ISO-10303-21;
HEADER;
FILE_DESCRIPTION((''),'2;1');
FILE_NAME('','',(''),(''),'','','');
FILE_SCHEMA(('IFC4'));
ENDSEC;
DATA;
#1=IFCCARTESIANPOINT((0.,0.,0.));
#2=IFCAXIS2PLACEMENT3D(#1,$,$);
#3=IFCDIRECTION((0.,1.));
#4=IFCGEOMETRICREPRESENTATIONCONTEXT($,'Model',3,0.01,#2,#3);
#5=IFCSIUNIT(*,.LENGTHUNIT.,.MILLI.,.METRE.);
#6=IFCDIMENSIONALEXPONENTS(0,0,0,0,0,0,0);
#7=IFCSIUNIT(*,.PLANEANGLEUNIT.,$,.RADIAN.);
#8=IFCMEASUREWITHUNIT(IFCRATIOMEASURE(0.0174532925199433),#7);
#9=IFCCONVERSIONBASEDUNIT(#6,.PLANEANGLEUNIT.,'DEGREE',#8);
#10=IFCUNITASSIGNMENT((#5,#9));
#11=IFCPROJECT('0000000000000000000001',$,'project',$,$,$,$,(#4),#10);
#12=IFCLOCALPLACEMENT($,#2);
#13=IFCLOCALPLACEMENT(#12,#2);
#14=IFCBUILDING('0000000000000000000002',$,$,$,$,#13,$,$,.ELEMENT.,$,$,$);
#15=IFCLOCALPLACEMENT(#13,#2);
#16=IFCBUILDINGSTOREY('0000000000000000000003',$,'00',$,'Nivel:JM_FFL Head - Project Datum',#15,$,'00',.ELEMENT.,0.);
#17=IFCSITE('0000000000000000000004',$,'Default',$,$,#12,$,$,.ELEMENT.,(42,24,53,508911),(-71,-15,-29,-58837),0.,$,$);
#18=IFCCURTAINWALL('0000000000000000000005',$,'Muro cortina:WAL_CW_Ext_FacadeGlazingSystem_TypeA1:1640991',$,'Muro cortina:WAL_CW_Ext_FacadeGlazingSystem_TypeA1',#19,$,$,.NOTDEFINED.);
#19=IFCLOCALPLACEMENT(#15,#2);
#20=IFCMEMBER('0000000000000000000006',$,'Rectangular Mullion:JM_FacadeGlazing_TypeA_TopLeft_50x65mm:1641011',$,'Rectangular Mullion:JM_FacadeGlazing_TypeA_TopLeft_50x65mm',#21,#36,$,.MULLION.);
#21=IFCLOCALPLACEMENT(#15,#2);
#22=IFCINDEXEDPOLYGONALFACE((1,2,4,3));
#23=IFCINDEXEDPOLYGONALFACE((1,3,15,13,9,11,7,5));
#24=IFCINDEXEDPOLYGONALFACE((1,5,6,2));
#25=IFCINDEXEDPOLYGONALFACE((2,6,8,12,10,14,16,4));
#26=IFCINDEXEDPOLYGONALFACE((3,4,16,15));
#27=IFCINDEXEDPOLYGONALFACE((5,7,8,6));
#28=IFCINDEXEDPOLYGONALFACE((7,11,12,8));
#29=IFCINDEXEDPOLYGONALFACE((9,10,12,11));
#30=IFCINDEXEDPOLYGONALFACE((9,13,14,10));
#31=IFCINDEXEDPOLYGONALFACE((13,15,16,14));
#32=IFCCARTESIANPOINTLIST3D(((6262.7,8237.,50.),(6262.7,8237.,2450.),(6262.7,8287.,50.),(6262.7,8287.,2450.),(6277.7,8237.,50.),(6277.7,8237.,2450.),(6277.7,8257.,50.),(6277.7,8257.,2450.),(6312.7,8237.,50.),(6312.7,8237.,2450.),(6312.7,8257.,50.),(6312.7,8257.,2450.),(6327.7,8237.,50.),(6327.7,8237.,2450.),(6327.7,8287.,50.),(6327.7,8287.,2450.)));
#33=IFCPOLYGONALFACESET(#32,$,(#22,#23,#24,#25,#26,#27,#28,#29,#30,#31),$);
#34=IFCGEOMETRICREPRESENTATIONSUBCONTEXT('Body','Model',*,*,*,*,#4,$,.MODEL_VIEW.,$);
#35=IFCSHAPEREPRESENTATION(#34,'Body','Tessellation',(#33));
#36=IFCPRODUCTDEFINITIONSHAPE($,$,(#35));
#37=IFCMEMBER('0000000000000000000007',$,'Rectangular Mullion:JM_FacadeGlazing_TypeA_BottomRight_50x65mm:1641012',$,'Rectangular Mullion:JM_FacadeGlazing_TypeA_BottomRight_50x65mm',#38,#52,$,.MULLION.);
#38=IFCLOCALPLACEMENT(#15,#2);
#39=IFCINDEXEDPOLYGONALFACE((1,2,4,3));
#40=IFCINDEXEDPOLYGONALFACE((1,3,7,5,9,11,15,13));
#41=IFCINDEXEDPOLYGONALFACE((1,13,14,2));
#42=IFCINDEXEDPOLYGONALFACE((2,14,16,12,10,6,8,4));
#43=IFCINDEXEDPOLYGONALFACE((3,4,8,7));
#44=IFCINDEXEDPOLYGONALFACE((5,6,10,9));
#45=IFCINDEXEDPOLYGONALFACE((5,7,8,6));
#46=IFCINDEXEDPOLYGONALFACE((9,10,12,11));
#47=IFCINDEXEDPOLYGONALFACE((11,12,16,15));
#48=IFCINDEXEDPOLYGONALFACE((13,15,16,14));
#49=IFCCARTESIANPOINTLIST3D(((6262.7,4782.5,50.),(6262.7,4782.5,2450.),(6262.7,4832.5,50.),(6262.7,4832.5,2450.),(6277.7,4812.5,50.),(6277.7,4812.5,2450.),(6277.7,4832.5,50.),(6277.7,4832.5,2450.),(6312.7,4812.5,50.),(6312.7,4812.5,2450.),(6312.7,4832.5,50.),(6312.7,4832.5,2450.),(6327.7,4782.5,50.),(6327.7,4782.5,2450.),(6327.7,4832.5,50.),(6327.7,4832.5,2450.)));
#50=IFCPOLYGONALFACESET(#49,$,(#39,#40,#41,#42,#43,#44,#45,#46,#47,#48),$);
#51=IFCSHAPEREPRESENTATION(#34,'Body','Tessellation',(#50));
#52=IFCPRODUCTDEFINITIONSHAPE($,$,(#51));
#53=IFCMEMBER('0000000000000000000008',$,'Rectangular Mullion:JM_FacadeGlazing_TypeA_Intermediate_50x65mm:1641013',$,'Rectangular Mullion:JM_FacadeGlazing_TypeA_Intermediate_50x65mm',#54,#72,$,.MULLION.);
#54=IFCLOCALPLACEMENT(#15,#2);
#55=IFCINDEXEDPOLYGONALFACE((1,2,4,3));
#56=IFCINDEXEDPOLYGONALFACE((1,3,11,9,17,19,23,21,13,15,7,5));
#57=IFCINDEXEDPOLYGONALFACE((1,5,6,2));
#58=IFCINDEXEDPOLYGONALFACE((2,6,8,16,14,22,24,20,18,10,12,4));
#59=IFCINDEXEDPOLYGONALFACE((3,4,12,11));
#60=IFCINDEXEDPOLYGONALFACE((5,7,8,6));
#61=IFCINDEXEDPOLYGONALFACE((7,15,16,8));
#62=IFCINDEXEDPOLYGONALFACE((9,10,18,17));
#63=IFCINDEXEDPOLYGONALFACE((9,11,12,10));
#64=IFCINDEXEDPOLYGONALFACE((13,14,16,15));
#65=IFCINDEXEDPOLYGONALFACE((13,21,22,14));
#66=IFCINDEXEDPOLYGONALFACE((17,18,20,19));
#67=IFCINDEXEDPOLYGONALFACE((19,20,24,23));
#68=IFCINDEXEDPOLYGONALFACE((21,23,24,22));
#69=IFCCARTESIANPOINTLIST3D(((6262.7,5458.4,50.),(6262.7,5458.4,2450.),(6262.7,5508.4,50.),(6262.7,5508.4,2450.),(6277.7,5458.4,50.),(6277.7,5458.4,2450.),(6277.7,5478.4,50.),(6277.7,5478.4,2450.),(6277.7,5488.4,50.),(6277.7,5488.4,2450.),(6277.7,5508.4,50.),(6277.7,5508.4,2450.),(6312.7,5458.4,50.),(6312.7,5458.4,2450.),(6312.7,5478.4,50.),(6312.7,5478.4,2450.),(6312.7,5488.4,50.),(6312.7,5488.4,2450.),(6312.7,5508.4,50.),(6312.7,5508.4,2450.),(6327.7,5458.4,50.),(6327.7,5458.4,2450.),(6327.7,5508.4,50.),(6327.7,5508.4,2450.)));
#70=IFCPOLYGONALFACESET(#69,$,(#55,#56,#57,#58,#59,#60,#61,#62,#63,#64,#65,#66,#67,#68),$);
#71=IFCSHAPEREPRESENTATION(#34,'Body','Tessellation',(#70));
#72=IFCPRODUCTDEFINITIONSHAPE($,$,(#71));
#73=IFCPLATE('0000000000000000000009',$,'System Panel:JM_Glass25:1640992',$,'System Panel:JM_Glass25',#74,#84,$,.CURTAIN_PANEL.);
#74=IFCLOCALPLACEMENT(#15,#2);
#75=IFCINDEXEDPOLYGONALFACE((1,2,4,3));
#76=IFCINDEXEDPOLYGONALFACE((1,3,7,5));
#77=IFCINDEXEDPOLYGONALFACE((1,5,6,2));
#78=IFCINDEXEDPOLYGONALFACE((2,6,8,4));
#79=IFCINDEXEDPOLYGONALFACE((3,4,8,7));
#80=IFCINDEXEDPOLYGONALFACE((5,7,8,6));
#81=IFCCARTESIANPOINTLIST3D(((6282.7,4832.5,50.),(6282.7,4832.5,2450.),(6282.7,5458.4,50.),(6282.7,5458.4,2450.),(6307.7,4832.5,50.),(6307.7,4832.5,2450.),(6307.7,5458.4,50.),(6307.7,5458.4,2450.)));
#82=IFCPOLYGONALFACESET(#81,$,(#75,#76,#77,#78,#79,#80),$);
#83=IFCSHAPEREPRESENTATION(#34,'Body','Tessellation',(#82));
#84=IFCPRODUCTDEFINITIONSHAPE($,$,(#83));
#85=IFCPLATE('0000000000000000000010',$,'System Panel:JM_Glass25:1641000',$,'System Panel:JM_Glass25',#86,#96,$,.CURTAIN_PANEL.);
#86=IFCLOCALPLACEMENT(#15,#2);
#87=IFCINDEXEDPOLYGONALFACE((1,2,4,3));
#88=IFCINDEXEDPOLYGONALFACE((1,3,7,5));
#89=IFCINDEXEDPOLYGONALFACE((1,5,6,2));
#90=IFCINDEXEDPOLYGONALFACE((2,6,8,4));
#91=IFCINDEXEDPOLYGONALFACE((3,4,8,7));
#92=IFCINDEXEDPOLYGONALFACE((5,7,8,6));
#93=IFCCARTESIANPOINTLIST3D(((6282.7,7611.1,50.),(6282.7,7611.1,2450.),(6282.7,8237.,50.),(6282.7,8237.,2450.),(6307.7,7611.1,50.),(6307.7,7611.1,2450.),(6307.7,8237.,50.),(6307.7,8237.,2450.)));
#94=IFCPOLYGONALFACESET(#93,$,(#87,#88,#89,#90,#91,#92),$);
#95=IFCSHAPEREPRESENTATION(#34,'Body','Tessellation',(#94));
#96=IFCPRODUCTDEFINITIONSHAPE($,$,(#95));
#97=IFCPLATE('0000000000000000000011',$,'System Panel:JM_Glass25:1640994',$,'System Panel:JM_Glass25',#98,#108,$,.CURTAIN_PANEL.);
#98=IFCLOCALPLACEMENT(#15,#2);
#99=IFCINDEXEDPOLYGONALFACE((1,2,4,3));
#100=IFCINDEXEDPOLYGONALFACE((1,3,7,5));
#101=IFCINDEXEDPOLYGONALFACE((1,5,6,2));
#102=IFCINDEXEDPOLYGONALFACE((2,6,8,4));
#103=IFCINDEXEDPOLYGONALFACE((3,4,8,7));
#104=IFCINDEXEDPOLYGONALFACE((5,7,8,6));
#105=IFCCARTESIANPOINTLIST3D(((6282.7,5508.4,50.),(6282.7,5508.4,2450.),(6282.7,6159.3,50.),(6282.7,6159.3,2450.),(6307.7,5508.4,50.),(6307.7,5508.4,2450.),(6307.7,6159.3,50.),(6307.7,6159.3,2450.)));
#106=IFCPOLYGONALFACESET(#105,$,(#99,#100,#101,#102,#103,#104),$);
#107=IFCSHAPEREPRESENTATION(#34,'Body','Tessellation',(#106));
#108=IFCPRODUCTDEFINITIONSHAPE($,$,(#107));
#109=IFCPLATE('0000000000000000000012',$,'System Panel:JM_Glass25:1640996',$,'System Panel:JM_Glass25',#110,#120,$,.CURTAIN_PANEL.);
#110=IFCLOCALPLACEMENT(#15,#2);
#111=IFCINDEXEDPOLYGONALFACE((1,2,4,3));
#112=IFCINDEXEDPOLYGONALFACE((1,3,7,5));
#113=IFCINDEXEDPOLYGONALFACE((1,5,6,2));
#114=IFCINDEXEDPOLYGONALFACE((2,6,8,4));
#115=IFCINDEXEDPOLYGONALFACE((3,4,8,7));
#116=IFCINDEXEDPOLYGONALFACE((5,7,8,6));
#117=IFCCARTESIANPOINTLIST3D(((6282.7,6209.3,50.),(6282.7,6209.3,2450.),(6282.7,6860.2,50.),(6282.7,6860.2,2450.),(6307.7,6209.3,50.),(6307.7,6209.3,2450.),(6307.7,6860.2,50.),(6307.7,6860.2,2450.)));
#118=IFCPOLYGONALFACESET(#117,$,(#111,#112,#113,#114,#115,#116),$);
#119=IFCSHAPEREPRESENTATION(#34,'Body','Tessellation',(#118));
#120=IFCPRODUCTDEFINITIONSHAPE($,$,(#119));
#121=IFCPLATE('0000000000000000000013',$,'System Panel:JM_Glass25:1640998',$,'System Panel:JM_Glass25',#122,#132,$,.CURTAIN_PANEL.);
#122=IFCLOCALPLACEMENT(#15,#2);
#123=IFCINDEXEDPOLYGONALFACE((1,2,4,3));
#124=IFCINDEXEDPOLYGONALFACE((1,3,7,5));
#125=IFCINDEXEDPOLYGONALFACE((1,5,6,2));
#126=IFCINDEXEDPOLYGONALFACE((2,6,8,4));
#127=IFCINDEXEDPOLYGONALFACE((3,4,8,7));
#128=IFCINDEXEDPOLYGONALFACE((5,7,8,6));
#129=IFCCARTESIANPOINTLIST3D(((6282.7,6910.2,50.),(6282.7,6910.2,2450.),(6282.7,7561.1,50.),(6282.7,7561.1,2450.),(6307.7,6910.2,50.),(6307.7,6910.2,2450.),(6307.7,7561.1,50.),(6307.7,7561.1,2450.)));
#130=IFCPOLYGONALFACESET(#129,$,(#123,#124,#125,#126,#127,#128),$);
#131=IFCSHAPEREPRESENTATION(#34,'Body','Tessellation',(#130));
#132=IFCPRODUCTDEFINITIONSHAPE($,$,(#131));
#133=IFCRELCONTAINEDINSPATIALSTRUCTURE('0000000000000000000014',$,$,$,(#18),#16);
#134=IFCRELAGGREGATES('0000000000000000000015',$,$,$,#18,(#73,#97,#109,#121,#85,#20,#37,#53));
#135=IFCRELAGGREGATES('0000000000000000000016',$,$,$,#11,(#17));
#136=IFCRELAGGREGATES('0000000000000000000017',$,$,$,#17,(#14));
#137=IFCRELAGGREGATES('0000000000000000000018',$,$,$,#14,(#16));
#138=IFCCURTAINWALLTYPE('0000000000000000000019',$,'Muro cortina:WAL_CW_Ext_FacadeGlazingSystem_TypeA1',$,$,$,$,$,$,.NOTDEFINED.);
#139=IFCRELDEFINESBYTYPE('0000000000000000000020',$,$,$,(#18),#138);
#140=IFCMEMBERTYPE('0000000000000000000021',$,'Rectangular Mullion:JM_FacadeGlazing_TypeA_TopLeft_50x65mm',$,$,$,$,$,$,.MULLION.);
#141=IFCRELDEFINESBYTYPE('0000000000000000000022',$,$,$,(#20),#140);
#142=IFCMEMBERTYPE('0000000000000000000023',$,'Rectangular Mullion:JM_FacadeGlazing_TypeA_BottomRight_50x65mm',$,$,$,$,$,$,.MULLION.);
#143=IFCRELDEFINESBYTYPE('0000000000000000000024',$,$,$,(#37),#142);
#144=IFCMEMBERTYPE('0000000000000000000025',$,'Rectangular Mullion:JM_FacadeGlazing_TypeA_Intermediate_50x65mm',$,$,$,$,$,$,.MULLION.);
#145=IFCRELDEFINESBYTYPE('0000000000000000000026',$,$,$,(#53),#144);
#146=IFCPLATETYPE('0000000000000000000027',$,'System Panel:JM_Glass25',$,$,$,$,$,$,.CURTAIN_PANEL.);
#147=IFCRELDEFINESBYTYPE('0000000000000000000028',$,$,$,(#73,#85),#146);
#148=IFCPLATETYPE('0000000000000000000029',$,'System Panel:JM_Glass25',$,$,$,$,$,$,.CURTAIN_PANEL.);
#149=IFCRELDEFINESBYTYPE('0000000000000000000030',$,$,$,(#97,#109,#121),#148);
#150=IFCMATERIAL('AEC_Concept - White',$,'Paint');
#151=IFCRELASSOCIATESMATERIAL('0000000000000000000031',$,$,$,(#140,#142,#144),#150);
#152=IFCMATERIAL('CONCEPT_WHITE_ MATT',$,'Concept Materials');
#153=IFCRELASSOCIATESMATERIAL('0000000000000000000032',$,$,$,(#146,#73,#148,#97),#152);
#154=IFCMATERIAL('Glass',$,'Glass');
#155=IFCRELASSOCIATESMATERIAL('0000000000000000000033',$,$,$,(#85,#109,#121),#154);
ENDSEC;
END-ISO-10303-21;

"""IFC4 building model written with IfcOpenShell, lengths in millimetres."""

from ifc_helpers import new_model, entity, si_unit, converted_unit, direction, frame, origin, place, context, subcontext, project, spatial, indexed_curve, outline, extrude, source, transform, mapped, material, type_object, type_shapes, element, aggregate, save


model = new_model("IFC4")

# Units and contexts
model_context = context("Model", 3, precision=0.01, world=origin(), true_north=direction((0.0, 1.0)))
body_context = subcontext(model_context, "Body", "Model", "MODEL_VIEW")
ifc_project = project(units=[si_unit("LENGTHUNIT", "METRE", prefix="MILLI"), converted_unit("PLANEANGLEUNIT", "DEGREE", entity("IfcRatioMeasure", 0.0174532925199433), si_unit("PLANEANGLEUNIT", "RADIAN"), dimensions=[0, 0, 0, 0, 0, 0, 0])], contexts=[model_context])

# Site, building, storey
site_placement = place(None, origin())
site = spatial("IfcSite", under=ifc_project, at=site_placement, Name="Default", CompositionType="ELEMENT", RefLatitude=(42, 24, 53, 508911), RefLongitude=(-71, -15, -29, -58837), RefElevation=0.0)
building_placement = place(site_placement, origin())
building = spatial("IfcBuilding", under=site, at=building_placement, CompositionType="ELEMENT")
storey_placement = place(building_placement, origin())
storey = spatial("IfcBuildingStorey", under=building, at=storey_placement, Name="00", ObjectType="Nivel:JM_FFL Head - Project Datum", LongName="00", CompositionType="ELEMENT", Elevation=0.0)

# Curtain wall, members, plates
curtain_wall_type = type_object("IfcCurtainWallType", Name="Muro cortina:WAL_CW_Ext_FacadeGlazingSystem_TypeA1", PredefinedType="NOTDEFINED")
curtain_wall_placement = place(storey_placement, origin())
curtain_wall = element("IfcCurtainWall", 1, at=curtain_wall_placement, inside=storey, type_object=curtain_wall_type, Name="Muro cortina:WAL_CW_Ext_FacadeGlazingSystem_TypeA1:1640991", ObjectType="Muro cortina:WAL_CW_Ext_FacadeGlazingSystem_TypeA1", PredefinedType="NOTDEFINED")
ifc_material_1 = material(Name="AEC_Concept - White", Category="Paint")
member_type_1 = type_object("IfcMemberType", Name="Rectangular Mullion:JM_FacadeGlazing_TypeA_TopLeft_50x65mm", PredefinedType="MULLION", material=ifc_material_1)
shared_shape_1 = source(origin(), body_context, "Body", "SweptSolid", [
    extrude(outline(indexed_curve([(-32.5, -17.5), (-17.5, -17.5), (-17.5, 2.5), (17.5, 2.5), (17.5, -17.5), (32.5, -17.5), (32.5, 32.5), (-32.5, 32.5), (-32.5, -17.5)], self_intersect=False)), frame((-32.5, 32.5, -2400.0), z_axis=(0.0, 0.0, 1.0), x_axis=(0.0, -1.0, 0.0)), (0.0, 0.0, 1.0), 2400.0),
])
type_shapes(member_type_1, [shared_shape_1])
member_1_placement = place(curtain_wall_placement, frame((6262.7, 8287.0, 50.0), z_axis=(0.0, 0.0, -1.0), x_axis=(0.0, 1.0, 0.0)))
member_1 = element("IfcMember", 2, at=member_1_placement, type_object=member_type_1, Name="Rectangular Mullion:JM_FacadeGlazing_TypeA_TopLeft_50x65mm:1641011", ObjectType="Rectangular Mullion:JM_FacadeGlazing_TypeA_TopLeft_50x65mm", PredefinedType="MULLION", context=body_context, shape_type="MappedRepresentation", body=[
    mapped(shared_shape_1, transform((0.0, 0.0, 0.0), scale=1.0)),
])
member_type_2 = type_object("IfcMemberType", Name="Rectangular Mullion:JM_FacadeGlazing_TypeA_BottomRight_50x65mm", PredefinedType="MULLION", material=ifc_material_1)
shared_shape_2 = source(origin(), body_context, "Body", "SweptSolid", [
    extrude(outline(indexed_curve([(-32.5, -17.5), (-17.5, -17.5), (-17.5, 2.5), (17.5, 2.5), (17.5, -17.5), (32.5, -17.5), (32.5, 32.5), (-32.5, 32.5), (-32.5, -17.5)], self_intersect=False)), frame((-32.5, 32.5, -2400.0), z_axis=(0.0, 0.0, 1.0), x_axis=(0.0, -1.0, 0.0)), (0.0, 0.0, 1.0), 2400.0),
])
type_shapes(member_type_2, [shared_shape_2])
member_2_placement = place(curtain_wall_placement, frame((6262.7, 4782.5, 2450.0), z_axis=(0.0, 0.0, 1.0), x_axis=(0.0, -1.0, 0.0)))
member_2 = element("IfcMember", 3, at=member_2_placement, type_object=member_type_2, Name="Rectangular Mullion:JM_FacadeGlazing_TypeA_BottomRight_50x65mm:1641012", ObjectType="Rectangular Mullion:JM_FacadeGlazing_TypeA_BottomRight_50x65mm", PredefinedType="MULLION", context=body_context, shape_type="MappedRepresentation", body=[
    mapped(shared_shape_2, transform((0.0, 0.0, 0.0), scale=1.0)),
])
member_type_3 = type_object("IfcMemberType", Name="Rectangular Mullion:JM_FacadeGlazing_TypeA_Intermediate_50x65mm", PredefinedType="MULLION", material=ifc_material_1)
shared_shape_3 = source(origin(), body_context, "Body", "SweptSolid", [
    extrude(outline(indexed_curve([(-32.5, -25.0), (-17.5, -25.0), (-17.5, -5.0), (17.5, -5.0), (17.5, -25.0), (32.5, -25.0), (32.5, 25.0), (17.5, 25.0), (17.5, 5.0), (-17.5, 5.0), (-17.5, 25.0), (-32.5, 25.0), (-32.5, -25.0)], self_intersect=False)), frame((0.0, 32.5, -2400.0), z_axis=(0.0, 0.0, 1.0), x_axis=(0.0, -1.0, 0.0)), (0.0, 0.0, 1.0), 2400.0),
])
type_shapes(member_type_3, [shared_shape_3])
member_3_placement = place(curtain_wall_placement, frame((6262.7, 5483.4, 50.0), z_axis=(0.0, 0.0, -1.0), x_axis=(0.0, 1.0, 0.0)))
member_3 = element("IfcMember", 4, at=member_3_placement, type_object=member_type_3, Name="Rectangular Mullion:JM_FacadeGlazing_TypeA_Intermediate_50x65mm:1641013", ObjectType="Rectangular Mullion:JM_FacadeGlazing_TypeA_Intermediate_50x65mm", PredefinedType="MULLION", context=body_context, shape_type="MappedRepresentation", body=[
    mapped(shared_shape_3, transform((0.0, 0.0, 0.0), scale=1.0)),
])
ifc_material_2 = material(Name="CONCEPT_WHITE_ MATT", Category="Concept Materials")
plate_type_1 = type_object("IfcPlateType", Name="System Panel:JM_Glass25", PredefinedType="CURTAIN_PANEL", material=ifc_material_2)
shared_shape_4 = source(origin(), body_context, "Body", "SweptSolid", [
    extrude(outline(indexed_curve([(-12.5, -312.9), (12.5, -312.9), (12.5, 312.9), (-12.5, 312.9), (-12.5, -312.9)], self_intersect=False)), frame((0.0, -32.5, 0.0), z_axis=(0.0, 0.0, 1.0), x_axis=(0.0, 1.0, 0.0)), (0.0, 0.0, 1.0), 2400.0),
])
type_shapes(plate_type_1, [shared_shape_4])
plate_1_placement = place(curtain_wall_placement, frame((6262.7, 5145.4, 50.0), z_axis=(0.0, 0.0, 1.0), x_axis=(0.0, 1.0, 0.0)))
plate_1 = element("IfcPlate", 5, at=plate_1_placement, type_object=plate_type_1, material=ifc_material_2, Name="System Panel:JM_Glass25:1640992", ObjectType="System Panel:JM_Glass25", PredefinedType="CURTAIN_PANEL", context=body_context, shape_type="MappedRepresentation", body=[
    mapped(shared_shape_4, transform((0.0, 0.0, 0.0), scale=1.0)),
])
ifc_material_3 = material(Name="Glass", Category="Glass")
plate_2_placement = place(curtain_wall_placement, frame((6262.7, 7924.0, 50.0), z_axis=(0.0, 0.0, 1.0), x_axis=(0.0, 1.0, 0.0)))
plate_2 = element("IfcPlate", 6, at=plate_2_placement, type_object=plate_type_1, material=ifc_material_3, Name="System Panel:JM_Glass25:1641000", ObjectType="System Panel:JM_Glass25", PredefinedType="CURTAIN_PANEL", context=body_context, shape_type="MappedRepresentation", body=[
    mapped(shared_shape_4, transform((0.0, 0.0, 0.0), scale=1.0)),
])
plate_type_2 = type_object("IfcPlateType", Name="System Panel:JM_Glass25", PredefinedType="CURTAIN_PANEL", material=ifc_material_2)
shared_shape_5 = source(origin(), body_context, "Body", "SweptSolid", [
    extrude(outline(indexed_curve([(-12.5, -325.4), (12.5, -325.4), (12.5, 325.4), (-12.5, 325.4), (-12.5, -325.4)], self_intersect=False)), frame((0.0, -32.5, 0.0), z_axis=(0.0, 0.0, 1.0), x_axis=(0.0, 1.0, 0.0)), (0.0, 0.0, 1.0), 2400.0),
])
type_shapes(plate_type_2, [shared_shape_5])
plate_3_placement = place(curtain_wall_placement, frame((6262.7, 5833.8, 50.0), z_axis=(0.0, 0.0, 1.0), x_axis=(0.0, 1.0, 0.0)))
plate_3 = element("IfcPlate", 7, at=plate_3_placement, type_object=plate_type_2, material=ifc_material_2, Name="System Panel:JM_Glass25:1640994", ObjectType="System Panel:JM_Glass25", PredefinedType="CURTAIN_PANEL", context=body_context, shape_type="MappedRepresentation", body=[
    mapped(shared_shape_5, transform((0.0, 0.0, 0.0), scale=1.0)),
])
plate_4_placement = place(curtain_wall_placement, frame((6262.7, 6534.7, 50.0), z_axis=(0.0, 0.0, 1.0), x_axis=(0.0, 1.0, 0.0)))
plate_4 = element("IfcPlate", 8, at=plate_4_placement, type_object=plate_type_2, material=ifc_material_3, Name="System Panel:JM_Glass25:1640996", ObjectType="System Panel:JM_Glass25", PredefinedType="CURTAIN_PANEL", context=body_context, shape_type="MappedRepresentation", body=[
    mapped(shared_shape_5, transform((0.0, 0.0, 0.0), scale=1.0)),
])
plate_5_placement = place(curtain_wall_placement, frame((6262.7, 7235.6, 50.0), z_axis=(0.0, 0.0, 1.0), x_axis=(0.0, 1.0, 0.0)))
plate_5 = element("IfcPlate", 9, at=plate_5_placement, type_object=plate_type_2, material=ifc_material_3, Name="System Panel:JM_Glass25:1640998", ObjectType="System Panel:JM_Glass25", PredefinedType="CURTAIN_PANEL", context=body_context, shape_type="MappedRepresentation", body=[
    mapped(shared_shape_5, transform((0.0, 0.0, 0.0), scale=1.0)),
])
aggregate(curtain_wall, [plate_1, plate_3, plate_4, plate_5, plate_2, member_1, member_2, member_3])

save(model, "model.ifc")
